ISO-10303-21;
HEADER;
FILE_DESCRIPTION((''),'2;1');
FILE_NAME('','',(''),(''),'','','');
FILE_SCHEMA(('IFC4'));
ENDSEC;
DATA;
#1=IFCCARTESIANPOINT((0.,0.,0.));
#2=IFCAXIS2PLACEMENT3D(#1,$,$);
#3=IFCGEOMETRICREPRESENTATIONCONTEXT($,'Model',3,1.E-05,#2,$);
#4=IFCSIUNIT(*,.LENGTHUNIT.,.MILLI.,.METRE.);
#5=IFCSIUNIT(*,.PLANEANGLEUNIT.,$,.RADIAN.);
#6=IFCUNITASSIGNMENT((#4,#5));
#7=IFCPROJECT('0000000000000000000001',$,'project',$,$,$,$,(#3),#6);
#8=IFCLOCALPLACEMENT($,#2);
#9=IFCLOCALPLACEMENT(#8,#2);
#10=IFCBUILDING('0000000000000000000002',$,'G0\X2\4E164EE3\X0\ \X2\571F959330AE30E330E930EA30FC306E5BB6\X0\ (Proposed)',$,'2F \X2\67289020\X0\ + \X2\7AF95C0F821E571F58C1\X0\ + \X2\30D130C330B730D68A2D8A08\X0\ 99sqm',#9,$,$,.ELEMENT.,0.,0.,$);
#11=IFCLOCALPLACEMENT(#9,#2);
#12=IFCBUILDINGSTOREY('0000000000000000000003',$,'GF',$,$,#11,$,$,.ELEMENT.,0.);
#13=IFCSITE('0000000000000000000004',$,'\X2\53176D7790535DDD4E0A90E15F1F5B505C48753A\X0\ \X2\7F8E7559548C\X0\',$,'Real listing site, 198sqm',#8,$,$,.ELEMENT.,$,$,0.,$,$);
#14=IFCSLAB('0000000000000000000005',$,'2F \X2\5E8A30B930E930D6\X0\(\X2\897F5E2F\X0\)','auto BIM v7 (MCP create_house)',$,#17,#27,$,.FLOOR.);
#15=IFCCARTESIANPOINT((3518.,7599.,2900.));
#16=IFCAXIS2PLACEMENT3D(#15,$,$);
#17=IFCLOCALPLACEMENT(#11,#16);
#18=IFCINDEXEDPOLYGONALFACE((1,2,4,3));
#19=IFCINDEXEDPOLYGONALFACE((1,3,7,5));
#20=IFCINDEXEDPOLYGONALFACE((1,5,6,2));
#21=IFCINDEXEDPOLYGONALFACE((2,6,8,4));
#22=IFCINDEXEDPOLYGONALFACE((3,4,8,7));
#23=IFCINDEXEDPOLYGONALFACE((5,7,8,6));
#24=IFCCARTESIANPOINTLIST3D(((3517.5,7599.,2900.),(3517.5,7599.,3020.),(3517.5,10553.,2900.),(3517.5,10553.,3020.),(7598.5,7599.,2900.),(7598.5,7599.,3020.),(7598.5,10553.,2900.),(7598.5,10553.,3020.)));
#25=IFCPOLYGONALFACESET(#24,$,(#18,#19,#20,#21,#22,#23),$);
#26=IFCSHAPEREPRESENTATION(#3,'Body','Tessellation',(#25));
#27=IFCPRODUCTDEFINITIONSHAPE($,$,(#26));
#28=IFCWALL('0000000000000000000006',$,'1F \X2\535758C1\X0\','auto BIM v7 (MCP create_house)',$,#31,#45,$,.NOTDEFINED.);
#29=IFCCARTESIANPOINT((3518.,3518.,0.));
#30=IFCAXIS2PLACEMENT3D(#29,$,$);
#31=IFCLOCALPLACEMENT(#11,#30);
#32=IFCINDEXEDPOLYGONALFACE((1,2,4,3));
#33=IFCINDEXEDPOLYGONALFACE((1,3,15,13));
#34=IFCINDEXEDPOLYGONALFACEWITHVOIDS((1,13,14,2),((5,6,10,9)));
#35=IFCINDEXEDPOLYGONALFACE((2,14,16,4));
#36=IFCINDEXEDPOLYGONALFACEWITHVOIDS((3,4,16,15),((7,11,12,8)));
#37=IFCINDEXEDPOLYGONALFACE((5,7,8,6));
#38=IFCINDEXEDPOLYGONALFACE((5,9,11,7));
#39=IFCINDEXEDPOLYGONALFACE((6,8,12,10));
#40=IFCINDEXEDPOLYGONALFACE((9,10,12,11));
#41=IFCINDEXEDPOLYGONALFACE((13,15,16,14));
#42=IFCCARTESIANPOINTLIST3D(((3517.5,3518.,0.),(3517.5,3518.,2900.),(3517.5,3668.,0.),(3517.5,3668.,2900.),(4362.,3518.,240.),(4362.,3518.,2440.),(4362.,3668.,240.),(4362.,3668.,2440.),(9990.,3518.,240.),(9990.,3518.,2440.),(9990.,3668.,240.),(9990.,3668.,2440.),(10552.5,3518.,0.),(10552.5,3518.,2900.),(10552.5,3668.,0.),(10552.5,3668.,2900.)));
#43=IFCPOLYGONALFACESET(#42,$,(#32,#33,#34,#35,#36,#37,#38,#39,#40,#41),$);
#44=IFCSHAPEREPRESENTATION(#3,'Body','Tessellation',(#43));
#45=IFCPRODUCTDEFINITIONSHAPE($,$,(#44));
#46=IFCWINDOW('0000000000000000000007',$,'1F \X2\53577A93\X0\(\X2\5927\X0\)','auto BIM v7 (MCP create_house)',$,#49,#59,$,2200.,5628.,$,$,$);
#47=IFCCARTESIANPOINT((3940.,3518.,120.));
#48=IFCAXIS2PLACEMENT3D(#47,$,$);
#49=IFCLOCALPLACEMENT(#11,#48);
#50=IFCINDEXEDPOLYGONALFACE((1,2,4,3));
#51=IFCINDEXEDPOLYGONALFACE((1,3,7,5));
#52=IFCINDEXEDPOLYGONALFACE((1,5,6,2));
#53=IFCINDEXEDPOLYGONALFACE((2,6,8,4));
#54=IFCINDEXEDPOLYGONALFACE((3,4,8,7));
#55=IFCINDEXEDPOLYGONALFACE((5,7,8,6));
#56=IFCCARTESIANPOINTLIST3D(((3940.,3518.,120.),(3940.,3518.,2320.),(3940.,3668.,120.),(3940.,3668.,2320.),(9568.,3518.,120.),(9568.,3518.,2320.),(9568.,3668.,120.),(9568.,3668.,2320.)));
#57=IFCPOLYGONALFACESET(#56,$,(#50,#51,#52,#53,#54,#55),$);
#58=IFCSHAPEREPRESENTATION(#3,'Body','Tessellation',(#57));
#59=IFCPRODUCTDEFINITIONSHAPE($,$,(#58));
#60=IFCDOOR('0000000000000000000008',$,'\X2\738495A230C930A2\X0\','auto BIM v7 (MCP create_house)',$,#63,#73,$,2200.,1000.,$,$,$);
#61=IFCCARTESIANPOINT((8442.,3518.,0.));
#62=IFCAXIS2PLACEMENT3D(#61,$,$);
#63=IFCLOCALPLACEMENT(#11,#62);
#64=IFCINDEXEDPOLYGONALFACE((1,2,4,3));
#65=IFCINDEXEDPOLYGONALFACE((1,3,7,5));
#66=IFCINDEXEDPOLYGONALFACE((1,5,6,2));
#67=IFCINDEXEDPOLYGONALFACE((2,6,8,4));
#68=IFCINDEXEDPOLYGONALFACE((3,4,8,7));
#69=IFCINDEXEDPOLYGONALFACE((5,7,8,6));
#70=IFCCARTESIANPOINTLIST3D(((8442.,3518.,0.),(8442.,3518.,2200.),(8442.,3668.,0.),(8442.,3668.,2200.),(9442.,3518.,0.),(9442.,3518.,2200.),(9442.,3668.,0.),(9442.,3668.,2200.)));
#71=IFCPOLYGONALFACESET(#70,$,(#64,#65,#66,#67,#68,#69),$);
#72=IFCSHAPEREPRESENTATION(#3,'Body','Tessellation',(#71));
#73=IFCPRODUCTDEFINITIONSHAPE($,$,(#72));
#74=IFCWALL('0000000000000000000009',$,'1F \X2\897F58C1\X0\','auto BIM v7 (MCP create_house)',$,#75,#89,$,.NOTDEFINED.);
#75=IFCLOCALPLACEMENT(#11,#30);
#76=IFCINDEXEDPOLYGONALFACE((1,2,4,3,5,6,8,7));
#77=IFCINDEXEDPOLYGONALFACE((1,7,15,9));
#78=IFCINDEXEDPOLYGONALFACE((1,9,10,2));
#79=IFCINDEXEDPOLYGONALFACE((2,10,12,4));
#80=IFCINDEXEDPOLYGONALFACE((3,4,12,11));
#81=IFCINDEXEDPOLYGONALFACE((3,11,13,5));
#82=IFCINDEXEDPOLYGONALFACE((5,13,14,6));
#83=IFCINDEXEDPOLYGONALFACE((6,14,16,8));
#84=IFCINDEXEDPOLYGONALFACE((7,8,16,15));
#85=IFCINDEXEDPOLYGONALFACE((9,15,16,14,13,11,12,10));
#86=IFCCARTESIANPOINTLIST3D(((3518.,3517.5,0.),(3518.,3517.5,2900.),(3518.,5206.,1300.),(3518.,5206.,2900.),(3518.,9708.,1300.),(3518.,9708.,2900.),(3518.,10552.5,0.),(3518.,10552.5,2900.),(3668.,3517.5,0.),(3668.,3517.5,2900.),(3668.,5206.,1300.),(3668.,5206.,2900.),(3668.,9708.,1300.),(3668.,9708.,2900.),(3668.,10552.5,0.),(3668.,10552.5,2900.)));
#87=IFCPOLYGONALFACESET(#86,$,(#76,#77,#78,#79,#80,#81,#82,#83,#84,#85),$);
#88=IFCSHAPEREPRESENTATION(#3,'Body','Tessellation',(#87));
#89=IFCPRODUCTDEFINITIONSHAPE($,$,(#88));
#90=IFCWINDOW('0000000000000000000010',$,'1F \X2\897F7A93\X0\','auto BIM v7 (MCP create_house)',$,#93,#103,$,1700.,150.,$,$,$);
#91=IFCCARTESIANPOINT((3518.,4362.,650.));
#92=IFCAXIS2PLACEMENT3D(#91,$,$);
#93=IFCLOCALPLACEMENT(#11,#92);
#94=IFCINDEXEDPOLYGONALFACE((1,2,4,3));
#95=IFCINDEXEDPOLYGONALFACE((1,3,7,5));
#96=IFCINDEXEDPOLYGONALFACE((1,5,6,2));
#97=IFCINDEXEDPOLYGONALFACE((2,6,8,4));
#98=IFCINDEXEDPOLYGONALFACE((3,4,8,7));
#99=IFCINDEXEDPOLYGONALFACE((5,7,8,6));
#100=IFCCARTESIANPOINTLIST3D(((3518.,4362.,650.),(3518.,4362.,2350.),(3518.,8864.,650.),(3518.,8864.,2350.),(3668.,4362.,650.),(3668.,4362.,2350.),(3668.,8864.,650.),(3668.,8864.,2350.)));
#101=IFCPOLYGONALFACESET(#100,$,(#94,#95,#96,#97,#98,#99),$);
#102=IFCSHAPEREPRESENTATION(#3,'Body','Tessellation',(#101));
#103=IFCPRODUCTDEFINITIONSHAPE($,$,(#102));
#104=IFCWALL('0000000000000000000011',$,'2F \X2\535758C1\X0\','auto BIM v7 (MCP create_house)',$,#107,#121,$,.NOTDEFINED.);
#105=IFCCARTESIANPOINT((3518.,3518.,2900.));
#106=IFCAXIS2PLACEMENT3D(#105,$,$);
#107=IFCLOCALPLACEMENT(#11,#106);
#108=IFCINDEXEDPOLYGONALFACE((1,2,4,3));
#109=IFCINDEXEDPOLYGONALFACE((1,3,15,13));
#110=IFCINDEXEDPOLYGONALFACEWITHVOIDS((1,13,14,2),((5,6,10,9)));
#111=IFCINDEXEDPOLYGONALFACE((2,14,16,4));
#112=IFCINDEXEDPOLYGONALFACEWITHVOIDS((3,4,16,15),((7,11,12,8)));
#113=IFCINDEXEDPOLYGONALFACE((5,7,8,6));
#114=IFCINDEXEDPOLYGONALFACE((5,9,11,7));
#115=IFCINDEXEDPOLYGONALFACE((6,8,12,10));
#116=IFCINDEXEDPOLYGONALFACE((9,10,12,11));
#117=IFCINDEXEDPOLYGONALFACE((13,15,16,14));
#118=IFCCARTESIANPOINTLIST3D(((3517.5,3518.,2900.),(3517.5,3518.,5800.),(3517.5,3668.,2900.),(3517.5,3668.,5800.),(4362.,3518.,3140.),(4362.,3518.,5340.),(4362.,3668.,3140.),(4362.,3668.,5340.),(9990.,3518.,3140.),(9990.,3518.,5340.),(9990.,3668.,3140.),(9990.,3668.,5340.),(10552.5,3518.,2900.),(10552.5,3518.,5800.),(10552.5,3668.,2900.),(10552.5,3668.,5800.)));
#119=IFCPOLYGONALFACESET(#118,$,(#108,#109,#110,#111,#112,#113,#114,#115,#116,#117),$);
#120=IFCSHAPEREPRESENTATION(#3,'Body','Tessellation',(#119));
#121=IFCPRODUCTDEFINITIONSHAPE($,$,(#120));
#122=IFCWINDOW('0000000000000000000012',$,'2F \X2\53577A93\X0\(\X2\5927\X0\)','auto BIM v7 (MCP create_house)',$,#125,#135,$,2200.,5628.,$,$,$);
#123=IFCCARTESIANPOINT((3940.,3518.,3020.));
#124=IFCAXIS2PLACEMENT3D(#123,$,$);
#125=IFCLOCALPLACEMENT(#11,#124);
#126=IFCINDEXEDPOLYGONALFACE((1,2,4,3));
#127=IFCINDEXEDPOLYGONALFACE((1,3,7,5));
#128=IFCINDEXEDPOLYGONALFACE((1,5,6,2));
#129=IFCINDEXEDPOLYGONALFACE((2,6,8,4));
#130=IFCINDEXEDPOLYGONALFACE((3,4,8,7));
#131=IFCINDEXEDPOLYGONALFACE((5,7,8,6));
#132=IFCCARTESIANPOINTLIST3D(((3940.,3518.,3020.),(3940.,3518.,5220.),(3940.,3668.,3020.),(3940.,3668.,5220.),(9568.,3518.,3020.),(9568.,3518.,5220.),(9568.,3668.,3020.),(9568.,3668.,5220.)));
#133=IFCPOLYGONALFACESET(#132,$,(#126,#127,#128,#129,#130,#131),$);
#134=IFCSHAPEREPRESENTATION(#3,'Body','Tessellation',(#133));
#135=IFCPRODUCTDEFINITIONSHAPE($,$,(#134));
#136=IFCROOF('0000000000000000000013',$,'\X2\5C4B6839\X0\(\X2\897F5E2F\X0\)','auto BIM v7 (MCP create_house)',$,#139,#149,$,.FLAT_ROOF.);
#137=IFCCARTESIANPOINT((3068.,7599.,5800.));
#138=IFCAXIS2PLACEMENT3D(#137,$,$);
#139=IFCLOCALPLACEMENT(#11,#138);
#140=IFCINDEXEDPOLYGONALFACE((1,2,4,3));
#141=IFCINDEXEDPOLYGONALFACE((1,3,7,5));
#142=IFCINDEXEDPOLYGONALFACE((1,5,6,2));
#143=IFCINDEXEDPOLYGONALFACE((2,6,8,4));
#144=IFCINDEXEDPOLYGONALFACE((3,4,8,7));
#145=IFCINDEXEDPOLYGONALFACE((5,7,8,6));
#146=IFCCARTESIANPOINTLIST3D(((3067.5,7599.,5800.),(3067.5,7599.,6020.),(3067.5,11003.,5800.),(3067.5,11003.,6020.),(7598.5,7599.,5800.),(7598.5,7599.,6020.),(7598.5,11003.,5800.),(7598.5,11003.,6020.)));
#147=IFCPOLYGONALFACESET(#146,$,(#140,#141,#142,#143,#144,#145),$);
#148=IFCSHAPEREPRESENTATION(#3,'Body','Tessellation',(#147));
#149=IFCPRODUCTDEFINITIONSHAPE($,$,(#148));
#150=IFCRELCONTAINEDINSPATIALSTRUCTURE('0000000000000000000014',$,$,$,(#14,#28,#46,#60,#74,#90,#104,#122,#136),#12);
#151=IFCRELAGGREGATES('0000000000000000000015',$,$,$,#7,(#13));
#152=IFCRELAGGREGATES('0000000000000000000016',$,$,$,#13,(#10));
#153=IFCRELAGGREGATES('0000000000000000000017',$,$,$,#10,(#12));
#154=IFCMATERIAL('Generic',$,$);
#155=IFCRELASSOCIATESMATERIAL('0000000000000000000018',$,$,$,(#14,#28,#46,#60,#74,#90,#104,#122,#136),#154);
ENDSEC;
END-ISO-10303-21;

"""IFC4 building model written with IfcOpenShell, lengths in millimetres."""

from ifc_helpers import new_model, si_unit, frame, frame_2d, origin, place, context, project, spatial, rectangle, extrude, material, element, fill, save


model = new_model("IFC4")

# Units and contexts
model_context = context("Model", 3, precision=1e-05, world=origin())
ifc_project = project(units=[si_unit("LENGTHUNIT", "METRE", prefix="MILLI"), si_unit("PLANEANGLEUNIT", "RADIAN")], contexts=[model_context])

# Site, building, storey
site_placement = place(None, origin())
site = spatial("IfcSite", under=ifc_project, at=site_placement, Name="北海道川上郡弟子屈町 美留和", ObjectType="Real listing site, 198sqm", CompositionType="ELEMENT", RefElevation=0.0)
building_placement = place(site_placement, origin())
building = spatial("IfcBuilding", under=site, at=building_placement, Name="G0世代 土間ギャラリーの家 (Proposed)", ObjectType="2F 木造 + 竹小舞土壁 + パッシブ設計 99sqm", CompositionType="ELEMENT", ElevationOfRefHeight=0.0, ElevationOfTerrain=0.0)
storey_placement = place(building_placement, origin())
storey = spatial("IfcBuildingStorey", under=building, at=storey_placement, Name="GF", CompositionType="ELEMENT", Elevation=0.0)

# Slab
ifc_material = material(Name="Generic")
slab_1_placement = place(storey_placement, frame((3518.0, 7599.0, 2900.0)))
element("IfcSlab", 1, at=slab_1_placement, inside=storey, material=ifc_material, Name="2F 床スラブ(西帯)", Description="auto BIM v7 (MCP create_house)", PredefinedType="FLOOR", context=model_context, shape_type="SweptSolid", body=[
    extrude(rectangle(XDim=4081.0, YDim=2954.0, at=frame_2d((2040.0, 1477.0))), frame((3518.0, 7599.0, 2900.0)), (0.0, 0.0, 1.0), 120.0),
])

# Wall, openings, window, door
wall_1_placement = place(storey_placement, frame((3518.0, 3518.0, 0.0)))
wall_1 = element("IfcWall", 2, at=wall_1_placement, inside=storey, material=ifc_material, Name="1F 南壁", Description="auto BIM v7 (MCP create_house)", PredefinedType="NOTDEFINED", context=model_context, shape_type="SweptSolid", body=[
    extrude(rectangle(XDim=7035.0, YDim=150.0, at=frame_2d((3517.0, 75.0))), frame((3518.0, 3518.0, 0.0)), (0.0, 0.0, 1.0), 2900.0),
])
opening_1_placement = place(storey_placement, frame((3940.0, 3518.0, 120.0)))
opening_1 = element("IfcOpeningElement", 3, at=opening_1_placement, cuts=wall_1, PredefinedType="NOTDEFINED", context=model_context, shape_type="SweptSolid", body=[
    extrude(rectangle(XDim=5628.0, YDim=150.0, at=frame_2d((2814.0, 75.0))), frame((3940.0, 3518.0, 120.0)), (0.0, 0.0, 1.0), 2200.0),
])
opening_2_placement = place(storey_placement, frame((8442.0, 3518.0, 0.0)))
opening_2 = element("IfcOpeningElement", 4, at=opening_2_placement, cuts=wall_1, PredefinedType="NOTDEFINED", context=model_context, shape_type="SweptSolid", body=[
    extrude(rectangle(XDim=1000.0, YDim=150.0, at=frame_2d((500.0, 75.0))), frame((8442.0, 3518.0, 0.0)), (0.0, 0.0, 1.0), 2200.0),
])
window_1_placement = place(storey_placement, frame((3940.0, 3518.0, 120.0)))
window_1 = element("IfcWindow", 5, at=window_1_placement, inside=storey, material=ifc_material, Name="1F 南窓(大)", Description="auto BIM v7 (MCP create_house)", OverallHeight=2200.0, OverallWidth=5628.0, context=model_context, shape_type="SweptSolid", body=[
    extrude(rectangle(XDim=5628.0, YDim=150.0, at=frame_2d((2814.0, 75.0))), frame((3940.0, 3518.0, 120.0)), (0.0, 0.0, 1.0), 2200.0),
])
fill(opening_1, window_1)
door_placement = place(storey_placement, frame((8442.0, 3518.0, 0.0)))
door = element("IfcDoor", 6, at=door_placement, inside=storey, material=ifc_material, Name="玄関ドア", Description="auto BIM v7 (MCP create_house)", OverallHeight=2200.0, OverallWidth=1000.0, context=model_context, shape_type="SweptSolid", body=[
    extrude(rectangle(XDim=1000.0, YDim=150.0, at=frame_2d((500.0, 75.0))), frame((8442.0, 3518.0, 0.0)), (0.0, 0.0, 1.0), 2200.0),
])
fill(opening_2, door)

# Wall, opening, window
wall_2_placement = place(storey_placement, frame((3518.0, 3518.0, 0.0)))
wall_2 = element("IfcWall", 7, at=wall_2_placement, inside=storey, material=ifc_material, Name="1F 西壁", Description="auto BIM v7 (MCP create_house)", PredefinedType="NOTDEFINED", context=model_context, shape_type="SweptSolid", body=[
    extrude(rectangle(XDim=150.0, YDim=7035.0, at=frame_2d((75.0, 3517.0))), frame((3518.0, 3518.0, 0.0)), (0.0, 0.0, 1.0), 2900.0),
])
opening_3_placement = place(storey_placement, frame((3518.0, 4362.0, 650.0)))
opening_3 = element("IfcOpeningElement", 8, at=opening_3_placement, cuts=wall_2, PredefinedType="NOTDEFINED", context=model_context, shape_type="SweptSolid", body=[
    extrude(rectangle(XDim=150.0, YDim=4502.0, at=frame_2d((75.0, 2251.0))), frame((3518.0, 4362.0, 650.0)), (0.0, 0.0, 1.0), 1700.0),
])
window_2_placement = place(storey_placement, frame((3518.0, 4362.0, 650.0)))
window_2 = element("IfcWindow", 9, at=window_2_placement, inside=storey, material=ifc_material, Name="1F 西窓", Description="auto BIM v7 (MCP create_house)", OverallHeight=1700.0, OverallWidth=150.0, context=model_context, shape_type="SweptSolid", body=[
    extrude(rectangle(XDim=150.0, YDim=4502.0, at=frame_2d((75.0, 2251.0))), frame((3518.0, 4362.0, 650.0)), (0.0, 0.0, 1.0), 1700.0),
])
fill(opening_3, window_2)

# Wall, opening, window
wall_3_placement = place(storey_placement, frame((3518.0, 3518.0, 2900.0)))
wall_3 = element("IfcWall", 10, at=wall_3_placement, inside=storey, material=ifc_material, Name="2F 南壁", Description="auto BIM v7 (MCP create_house)", PredefinedType="NOTDEFINED", context=model_context, shape_type="SweptSolid", body=[
    extrude(rectangle(XDim=7035.0, YDim=150.0, at=frame_2d((3517.0, 75.0))), frame((3518.0, 3518.0, 2900.0)), (0.0, 0.0, 1.0), 2900.0),
])
opening_4_placement = place(storey_placement, frame((3940.0, 3518.0, 3020.0)))
opening_4 = element("IfcOpeningElement", 11, at=opening_4_placement, cuts=wall_3, PredefinedType="NOTDEFINED", context=model_context, shape_type="SweptSolid", body=[
    extrude(rectangle(XDim=5628.0, YDim=150.0, at=frame_2d((2814.0, 75.0))), frame((3940.0, 3518.0, 3020.0)), (0.0, 0.0, 1.0), 2200.0),
])
window_3_placement = place(storey_placement, frame((3940.0, 3518.0, 3020.0)))
window_3 = element("IfcWindow", 12, at=window_3_placement, inside=storey, material=ifc_material, Name="2F 南窓(大)", Description="auto BIM v7 (MCP create_house)", OverallHeight=2200.0, OverallWidth=5628.0, context=model_context, shape_type="SweptSolid", body=[
    extrude(rectangle(XDim=5628.0, YDim=150.0, at=frame_2d((2814.0, 75.0))), frame((3940.0, 3518.0, 3020.0)), (0.0, 0.0, 1.0), 2200.0),
])
fill(opening_4, window_3)

# Roof
roof_1_placement = place(storey_placement, frame((3068.0, 7599.0, 5800.0)))
element("IfcRoof", 13, at=roof_1_placement, inside=storey, material=ifc_material, Name="屋根(西帯)", Description="auto BIM v7 (MCP create_house)", PredefinedType="FLAT_ROOF", context=model_context, shape_type="SweptSolid", body=[
    extrude(rectangle(XDim=4531.0, YDim=3404.0, at=frame_2d((2265.0, 1702.0))), frame((3068.0, 7599.0, 5800.0)), (0.0, 0.0, 1.0), 220.0),
])

save(model, "model.ifc")
